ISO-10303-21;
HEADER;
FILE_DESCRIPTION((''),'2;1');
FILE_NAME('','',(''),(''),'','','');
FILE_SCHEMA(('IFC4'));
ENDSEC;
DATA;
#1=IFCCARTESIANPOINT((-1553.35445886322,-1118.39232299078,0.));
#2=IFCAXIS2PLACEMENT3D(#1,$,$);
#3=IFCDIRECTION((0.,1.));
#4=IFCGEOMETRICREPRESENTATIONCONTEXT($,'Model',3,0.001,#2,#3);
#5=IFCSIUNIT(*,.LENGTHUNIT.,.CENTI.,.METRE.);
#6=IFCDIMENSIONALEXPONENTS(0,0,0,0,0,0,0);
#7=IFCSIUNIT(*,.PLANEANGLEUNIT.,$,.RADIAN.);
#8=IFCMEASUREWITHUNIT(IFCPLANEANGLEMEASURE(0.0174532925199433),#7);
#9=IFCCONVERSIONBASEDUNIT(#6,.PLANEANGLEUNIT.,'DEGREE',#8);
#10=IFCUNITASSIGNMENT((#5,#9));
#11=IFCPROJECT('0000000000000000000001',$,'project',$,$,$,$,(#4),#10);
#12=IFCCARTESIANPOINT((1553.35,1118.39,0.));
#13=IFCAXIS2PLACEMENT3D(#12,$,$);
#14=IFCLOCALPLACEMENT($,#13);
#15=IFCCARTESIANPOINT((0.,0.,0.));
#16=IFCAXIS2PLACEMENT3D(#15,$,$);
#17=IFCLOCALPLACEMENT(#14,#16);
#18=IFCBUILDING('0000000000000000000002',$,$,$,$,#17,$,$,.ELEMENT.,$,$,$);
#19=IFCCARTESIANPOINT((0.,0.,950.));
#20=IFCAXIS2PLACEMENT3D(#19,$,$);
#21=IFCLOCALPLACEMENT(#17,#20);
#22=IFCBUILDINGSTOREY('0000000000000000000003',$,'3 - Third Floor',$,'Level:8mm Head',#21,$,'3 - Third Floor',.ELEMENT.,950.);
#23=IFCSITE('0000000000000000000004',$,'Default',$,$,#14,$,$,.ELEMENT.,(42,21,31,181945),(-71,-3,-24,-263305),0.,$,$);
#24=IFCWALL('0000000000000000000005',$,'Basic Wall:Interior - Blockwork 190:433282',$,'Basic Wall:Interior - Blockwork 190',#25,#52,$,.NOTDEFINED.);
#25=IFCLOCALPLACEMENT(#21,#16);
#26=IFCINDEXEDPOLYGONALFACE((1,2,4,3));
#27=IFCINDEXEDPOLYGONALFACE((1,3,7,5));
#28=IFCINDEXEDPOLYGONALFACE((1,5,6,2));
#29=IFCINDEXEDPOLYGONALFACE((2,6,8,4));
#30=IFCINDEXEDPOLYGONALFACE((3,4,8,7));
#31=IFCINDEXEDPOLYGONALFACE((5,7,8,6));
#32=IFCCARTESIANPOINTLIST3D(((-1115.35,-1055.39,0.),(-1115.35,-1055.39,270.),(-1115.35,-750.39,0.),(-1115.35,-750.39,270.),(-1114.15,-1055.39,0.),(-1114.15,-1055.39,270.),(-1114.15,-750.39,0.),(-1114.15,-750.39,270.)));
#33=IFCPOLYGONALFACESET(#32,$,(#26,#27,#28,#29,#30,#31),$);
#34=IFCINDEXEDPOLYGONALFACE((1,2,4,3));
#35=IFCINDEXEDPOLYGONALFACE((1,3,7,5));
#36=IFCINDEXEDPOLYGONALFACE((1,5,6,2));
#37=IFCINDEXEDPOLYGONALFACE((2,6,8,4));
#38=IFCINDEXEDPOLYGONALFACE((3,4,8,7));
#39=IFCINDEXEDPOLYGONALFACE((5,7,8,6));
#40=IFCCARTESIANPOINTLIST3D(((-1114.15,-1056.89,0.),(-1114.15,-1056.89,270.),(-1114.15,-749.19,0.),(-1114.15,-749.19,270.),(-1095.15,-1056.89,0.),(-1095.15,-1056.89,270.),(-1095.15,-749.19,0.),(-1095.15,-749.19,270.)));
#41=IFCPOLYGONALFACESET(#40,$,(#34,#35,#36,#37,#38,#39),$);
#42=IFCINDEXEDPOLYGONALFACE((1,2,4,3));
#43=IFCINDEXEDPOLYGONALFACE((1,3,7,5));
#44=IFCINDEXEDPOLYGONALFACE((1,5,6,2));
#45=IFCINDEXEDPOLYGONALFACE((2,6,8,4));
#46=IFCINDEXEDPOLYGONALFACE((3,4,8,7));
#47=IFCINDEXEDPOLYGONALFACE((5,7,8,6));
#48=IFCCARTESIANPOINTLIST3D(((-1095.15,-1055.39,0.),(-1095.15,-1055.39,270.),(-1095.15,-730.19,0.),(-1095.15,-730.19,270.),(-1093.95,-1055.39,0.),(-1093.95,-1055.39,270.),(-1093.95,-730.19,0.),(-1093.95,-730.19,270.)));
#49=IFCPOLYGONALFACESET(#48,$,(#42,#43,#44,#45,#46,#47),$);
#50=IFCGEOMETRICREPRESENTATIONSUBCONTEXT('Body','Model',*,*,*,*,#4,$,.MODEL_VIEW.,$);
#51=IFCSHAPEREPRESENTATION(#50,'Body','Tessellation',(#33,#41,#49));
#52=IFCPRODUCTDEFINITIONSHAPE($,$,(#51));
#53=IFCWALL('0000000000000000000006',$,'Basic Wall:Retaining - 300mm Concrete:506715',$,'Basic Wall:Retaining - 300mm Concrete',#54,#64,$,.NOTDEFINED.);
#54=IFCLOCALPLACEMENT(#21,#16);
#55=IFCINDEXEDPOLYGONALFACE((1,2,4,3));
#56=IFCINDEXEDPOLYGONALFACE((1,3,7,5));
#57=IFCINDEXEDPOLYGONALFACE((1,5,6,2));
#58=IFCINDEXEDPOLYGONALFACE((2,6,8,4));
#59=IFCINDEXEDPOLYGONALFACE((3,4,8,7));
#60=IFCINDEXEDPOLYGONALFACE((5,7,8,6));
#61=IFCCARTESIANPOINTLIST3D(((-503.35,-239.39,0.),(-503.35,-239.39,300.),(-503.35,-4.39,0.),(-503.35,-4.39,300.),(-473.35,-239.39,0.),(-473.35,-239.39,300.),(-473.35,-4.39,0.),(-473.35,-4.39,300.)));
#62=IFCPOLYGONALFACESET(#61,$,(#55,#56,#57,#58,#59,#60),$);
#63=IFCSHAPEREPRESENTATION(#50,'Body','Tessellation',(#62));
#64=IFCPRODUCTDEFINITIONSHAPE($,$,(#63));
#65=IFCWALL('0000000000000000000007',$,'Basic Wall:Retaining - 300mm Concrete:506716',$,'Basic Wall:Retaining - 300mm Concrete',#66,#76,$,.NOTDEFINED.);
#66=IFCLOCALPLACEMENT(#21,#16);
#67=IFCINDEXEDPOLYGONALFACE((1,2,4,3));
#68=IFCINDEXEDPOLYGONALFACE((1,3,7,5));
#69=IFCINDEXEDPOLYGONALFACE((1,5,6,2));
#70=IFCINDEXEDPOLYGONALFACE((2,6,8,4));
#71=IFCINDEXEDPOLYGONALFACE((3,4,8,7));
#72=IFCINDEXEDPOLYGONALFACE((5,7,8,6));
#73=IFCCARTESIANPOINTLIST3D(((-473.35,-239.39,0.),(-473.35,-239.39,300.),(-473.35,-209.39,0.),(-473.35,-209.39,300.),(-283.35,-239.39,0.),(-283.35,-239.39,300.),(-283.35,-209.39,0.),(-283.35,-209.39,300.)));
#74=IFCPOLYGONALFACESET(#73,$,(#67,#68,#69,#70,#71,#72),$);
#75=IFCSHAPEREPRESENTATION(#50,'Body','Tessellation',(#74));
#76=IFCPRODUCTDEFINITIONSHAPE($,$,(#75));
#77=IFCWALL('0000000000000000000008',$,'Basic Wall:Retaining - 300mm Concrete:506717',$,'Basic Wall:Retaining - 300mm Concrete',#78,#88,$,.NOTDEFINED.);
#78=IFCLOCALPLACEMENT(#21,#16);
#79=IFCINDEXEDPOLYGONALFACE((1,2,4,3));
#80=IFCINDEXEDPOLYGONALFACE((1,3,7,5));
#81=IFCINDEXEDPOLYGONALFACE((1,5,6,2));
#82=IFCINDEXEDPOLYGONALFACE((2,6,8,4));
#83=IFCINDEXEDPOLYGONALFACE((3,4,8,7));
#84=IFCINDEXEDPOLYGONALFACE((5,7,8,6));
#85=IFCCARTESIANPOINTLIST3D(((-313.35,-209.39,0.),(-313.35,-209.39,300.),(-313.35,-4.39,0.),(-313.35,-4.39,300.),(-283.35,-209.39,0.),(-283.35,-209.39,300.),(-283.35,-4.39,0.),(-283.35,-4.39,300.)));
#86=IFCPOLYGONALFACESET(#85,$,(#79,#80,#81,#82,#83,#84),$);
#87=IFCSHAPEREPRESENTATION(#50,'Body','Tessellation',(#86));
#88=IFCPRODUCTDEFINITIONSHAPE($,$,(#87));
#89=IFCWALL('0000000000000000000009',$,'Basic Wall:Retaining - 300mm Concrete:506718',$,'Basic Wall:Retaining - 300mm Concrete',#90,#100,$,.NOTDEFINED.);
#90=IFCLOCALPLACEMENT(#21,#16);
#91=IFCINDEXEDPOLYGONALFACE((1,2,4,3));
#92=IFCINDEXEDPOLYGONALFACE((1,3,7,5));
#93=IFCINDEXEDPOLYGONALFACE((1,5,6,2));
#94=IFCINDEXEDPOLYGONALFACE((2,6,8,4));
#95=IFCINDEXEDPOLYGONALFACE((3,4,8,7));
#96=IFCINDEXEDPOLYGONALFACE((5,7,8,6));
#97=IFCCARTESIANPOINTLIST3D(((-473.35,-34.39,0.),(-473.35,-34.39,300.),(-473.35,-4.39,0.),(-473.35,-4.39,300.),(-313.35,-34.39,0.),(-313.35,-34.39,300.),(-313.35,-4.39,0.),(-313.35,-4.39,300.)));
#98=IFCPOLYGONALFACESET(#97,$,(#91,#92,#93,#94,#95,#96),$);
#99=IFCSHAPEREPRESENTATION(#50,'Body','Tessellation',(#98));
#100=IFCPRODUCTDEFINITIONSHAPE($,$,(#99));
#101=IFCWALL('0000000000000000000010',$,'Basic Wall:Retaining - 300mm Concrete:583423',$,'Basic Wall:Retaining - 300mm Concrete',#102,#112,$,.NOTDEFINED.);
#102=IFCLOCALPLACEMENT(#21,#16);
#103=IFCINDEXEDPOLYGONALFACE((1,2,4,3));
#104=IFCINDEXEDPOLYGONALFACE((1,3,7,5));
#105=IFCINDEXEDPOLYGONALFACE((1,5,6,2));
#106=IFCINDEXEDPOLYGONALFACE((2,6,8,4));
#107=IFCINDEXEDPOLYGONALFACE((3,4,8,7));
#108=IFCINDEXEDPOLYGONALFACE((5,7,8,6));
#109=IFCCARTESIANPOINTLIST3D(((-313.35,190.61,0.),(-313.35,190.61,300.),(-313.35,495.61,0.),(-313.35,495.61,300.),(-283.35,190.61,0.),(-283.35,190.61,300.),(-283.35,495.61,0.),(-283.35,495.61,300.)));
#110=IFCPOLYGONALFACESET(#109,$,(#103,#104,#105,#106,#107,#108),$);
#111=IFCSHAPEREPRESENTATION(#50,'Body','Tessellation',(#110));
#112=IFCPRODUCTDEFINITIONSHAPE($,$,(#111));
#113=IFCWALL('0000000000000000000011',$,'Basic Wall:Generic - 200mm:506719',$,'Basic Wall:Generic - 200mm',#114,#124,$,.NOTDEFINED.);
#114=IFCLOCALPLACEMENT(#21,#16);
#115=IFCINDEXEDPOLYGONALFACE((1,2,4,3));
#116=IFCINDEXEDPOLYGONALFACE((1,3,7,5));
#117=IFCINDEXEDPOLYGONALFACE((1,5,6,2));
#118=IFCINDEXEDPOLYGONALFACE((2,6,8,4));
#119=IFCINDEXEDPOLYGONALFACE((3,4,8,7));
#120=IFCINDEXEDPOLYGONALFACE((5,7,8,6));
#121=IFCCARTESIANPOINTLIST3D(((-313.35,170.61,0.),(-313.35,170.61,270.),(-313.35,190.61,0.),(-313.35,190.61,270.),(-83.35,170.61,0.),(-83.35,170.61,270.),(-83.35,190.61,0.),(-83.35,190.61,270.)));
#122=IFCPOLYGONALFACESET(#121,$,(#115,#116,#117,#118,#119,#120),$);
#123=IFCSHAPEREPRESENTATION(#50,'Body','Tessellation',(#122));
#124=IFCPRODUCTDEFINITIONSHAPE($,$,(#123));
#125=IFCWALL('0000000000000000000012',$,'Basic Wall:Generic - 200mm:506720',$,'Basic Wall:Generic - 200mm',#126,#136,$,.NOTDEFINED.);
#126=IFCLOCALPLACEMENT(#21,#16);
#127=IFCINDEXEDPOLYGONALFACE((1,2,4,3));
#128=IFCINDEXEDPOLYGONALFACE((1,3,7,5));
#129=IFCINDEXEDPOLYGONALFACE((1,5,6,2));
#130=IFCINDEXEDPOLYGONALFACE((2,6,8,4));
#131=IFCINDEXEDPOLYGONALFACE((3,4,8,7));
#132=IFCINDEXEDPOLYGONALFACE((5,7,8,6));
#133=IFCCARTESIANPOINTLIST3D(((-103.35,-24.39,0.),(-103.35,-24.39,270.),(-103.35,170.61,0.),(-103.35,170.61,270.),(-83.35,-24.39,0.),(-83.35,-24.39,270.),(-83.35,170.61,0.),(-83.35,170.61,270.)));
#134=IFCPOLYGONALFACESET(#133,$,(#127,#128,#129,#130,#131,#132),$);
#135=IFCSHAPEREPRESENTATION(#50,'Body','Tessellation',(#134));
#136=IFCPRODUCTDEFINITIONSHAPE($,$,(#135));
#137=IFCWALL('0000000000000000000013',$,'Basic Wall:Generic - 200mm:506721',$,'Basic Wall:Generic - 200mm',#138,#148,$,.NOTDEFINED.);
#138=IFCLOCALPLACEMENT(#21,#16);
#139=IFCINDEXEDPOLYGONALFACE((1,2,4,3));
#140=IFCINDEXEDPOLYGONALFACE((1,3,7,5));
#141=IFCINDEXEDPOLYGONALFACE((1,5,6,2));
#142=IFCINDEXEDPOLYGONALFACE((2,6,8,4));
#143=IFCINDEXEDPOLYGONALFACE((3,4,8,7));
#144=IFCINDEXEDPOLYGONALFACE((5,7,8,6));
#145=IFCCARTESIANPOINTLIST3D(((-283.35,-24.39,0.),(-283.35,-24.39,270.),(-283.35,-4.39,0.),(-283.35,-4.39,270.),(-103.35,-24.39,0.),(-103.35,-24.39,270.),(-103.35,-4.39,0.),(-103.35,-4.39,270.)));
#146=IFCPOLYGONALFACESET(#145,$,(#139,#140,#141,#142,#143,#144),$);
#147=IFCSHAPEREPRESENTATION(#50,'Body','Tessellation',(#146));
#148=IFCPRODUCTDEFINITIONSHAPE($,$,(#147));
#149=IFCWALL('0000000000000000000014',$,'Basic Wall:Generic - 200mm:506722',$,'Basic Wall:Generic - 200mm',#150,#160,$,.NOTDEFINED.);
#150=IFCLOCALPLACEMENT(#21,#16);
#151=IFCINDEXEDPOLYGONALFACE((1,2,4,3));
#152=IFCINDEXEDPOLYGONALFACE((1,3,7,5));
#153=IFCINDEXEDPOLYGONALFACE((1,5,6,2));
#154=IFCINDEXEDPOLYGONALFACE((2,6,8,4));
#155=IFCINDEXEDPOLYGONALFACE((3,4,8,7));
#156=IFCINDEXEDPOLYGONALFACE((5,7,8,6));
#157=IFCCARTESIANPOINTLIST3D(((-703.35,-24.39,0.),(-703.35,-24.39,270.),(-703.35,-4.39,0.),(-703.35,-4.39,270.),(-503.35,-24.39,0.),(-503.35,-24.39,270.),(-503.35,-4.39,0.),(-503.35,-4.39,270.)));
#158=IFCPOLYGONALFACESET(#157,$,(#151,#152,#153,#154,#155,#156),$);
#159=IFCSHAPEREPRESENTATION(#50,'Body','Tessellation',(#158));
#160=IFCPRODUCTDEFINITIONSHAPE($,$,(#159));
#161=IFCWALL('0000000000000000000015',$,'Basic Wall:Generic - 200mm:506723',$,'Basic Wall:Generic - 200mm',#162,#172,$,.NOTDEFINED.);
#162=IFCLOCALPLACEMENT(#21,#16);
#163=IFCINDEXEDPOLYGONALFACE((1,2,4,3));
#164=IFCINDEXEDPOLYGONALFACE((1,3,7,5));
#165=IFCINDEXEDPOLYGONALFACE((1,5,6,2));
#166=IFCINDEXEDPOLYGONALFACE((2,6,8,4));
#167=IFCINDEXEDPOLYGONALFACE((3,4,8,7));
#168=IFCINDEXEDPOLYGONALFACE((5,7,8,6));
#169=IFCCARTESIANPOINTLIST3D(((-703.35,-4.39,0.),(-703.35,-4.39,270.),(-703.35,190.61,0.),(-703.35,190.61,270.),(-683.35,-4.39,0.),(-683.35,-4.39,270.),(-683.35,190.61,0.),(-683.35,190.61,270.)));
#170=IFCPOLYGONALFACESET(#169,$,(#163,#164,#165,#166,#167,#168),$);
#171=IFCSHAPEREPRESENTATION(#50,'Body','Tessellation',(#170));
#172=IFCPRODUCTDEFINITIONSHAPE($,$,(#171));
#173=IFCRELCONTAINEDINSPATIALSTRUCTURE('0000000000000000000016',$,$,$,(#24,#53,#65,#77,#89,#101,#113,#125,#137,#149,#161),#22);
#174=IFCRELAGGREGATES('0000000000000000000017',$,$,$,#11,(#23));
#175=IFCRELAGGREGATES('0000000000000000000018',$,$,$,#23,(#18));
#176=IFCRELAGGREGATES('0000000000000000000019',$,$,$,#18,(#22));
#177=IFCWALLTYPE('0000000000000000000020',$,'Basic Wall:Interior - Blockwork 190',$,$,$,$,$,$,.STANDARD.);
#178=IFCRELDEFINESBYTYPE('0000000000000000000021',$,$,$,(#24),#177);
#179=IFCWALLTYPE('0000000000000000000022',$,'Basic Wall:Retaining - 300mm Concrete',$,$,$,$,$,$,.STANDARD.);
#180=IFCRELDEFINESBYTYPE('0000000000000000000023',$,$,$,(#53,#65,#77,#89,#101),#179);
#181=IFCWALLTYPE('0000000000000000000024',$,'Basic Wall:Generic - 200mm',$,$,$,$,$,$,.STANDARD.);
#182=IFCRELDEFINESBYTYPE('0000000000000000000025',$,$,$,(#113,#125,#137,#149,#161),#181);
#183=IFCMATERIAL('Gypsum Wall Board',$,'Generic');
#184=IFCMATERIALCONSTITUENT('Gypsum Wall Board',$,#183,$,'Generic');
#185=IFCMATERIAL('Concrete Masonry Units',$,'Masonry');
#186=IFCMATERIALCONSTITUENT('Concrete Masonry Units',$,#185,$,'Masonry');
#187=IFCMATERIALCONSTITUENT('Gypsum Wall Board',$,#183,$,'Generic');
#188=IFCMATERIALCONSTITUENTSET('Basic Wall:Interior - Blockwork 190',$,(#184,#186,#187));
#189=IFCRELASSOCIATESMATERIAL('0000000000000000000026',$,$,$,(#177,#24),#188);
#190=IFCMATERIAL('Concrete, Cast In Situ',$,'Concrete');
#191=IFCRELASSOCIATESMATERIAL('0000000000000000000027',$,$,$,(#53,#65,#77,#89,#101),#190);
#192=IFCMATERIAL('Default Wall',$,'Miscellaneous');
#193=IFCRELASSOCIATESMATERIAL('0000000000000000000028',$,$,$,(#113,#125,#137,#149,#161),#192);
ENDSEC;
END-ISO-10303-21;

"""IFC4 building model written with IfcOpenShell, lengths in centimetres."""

from ifc_helpers import new_model, entity, si_unit, converted_unit, direction, frame, origin, place, context, subcontext, project, spatial, indexed_curve, outline, extrude, material, constituent, constituent_set, type_object, element, save


model = new_model("IFC4")

# Units and contexts
model_context = context("Model", 3, precision=0.001, world=frame((-1553.35445886322, -1118.39232299078, 0.0)), true_north=direction((0.0, 1.0)))
body_context = subcontext(model_context, "Body", "Model", "MODEL_VIEW")
ifc_project = project(units=[si_unit("LENGTHUNIT", "METRE", prefix="CENTI"), converted_unit("PLANEANGLEUNIT", "DEGREE", entity("IfcPlaneAngleMeasure", 0.0174532925199433), si_unit("PLANEANGLEUNIT", "RADIAN"), dimensions=[0, 0, 0, 0, 0, 0, 0])], contexts=[model_context])

# Site, building, storey
site_placement = place(None, frame((1553.35, 1118.39, 0.0)))
site = spatial("IfcSite", under=ifc_project, at=site_placement, Name="Default", CompositionType="ELEMENT", RefLatitude=(42, 21, 31, 181945), RefLongitude=(-71, -3, -24, -263305), RefElevation=0.0)
building_placement = place(site_placement, origin())
building = spatial("IfcBuilding", under=site, at=building_placement, CompositionType="ELEMENT")
storey_placement = place(building_placement, frame((0.0, 0.0, 950.0)))
storey = spatial("IfcBuildingStorey", under=building, at=storey_placement, Name="3 - Third Floor", ObjectType="Level:8mm Head", LongName="3 - Third Floor", CompositionType="ELEMENT", Elevation=950.0)

# Shared definitions
ifc_material_1 = material(Name="Concrete Masonry Units", Category="Masonry")

# Shared definitions
ifc_material_2 = material(Name="Gypsum Wall Board", Category="Generic")
ifc_constituent_1 = constituent(ifc_material_2, Name="Gypsum Wall Board", Category="Generic")
ifc_constituent_2 = constituent(ifc_material_1, Name="Concrete Masonry Units", Category="Masonry")
ifc_constituent_3 = constituent(ifc_material_2, Name="Gypsum Wall Board", Category="Generic")
ifc_constituent_set_1 = constituent_set(constituents=[ifc_constituent_1, ifc_constituent_2, ifc_constituent_3], Name="Basic Wall:Interior - Blockwork 190")
wall_type_1 = type_object("IfcWallType", Name="Basic Wall:Interior - Blockwork 190", PredefinedType="STANDARD", material=ifc_constituent_set_1)

# Walls
wall_1_placement = place(storey_placement, frame((-1104.65, -750.39, 0.0), z_axis=(0.0, 0.0, 1.0), x_axis=(0.0, -1.0, 0.0)))
element("IfcWall", 1, at=wall_1_placement, inside=storey, type_object=wall_type_1, material=ifc_constituent_set_1, Name="Basic Wall:Interior - Blockwork 190:433282", ObjectType="Basic Wall:Interior - Blockwork 190", PredefinedType="NOTDEFINED", context=body_context, shape_type="SweptSolid", body=[
    extrude(outline(indexed_curve([(-0.6, -152.5), (0.6, -152.5), (0.6, 152.5), (-0.6, 152.5), (-0.6, -152.5)], self_intersect=False)), frame((152.5, -10.1, 0.0), z_axis=(0.0, 0.0, 1.0), x_axis=(0.0, 1.0, 0.0)), (0.0, 0.0, 1.0), 270.0),
    extrude(outline(indexed_curve([(-153.85, -9.5), (153.85, -9.5), (153.85, 9.5), (-153.85, 9.5), (-153.85, -9.5)], self_intersect=False)), frame((152.65, 0.0, 0.0)), (0.0, 0.0, 1.0), 270.0),
    extrude(outline(indexed_curve([(-0.6, -162.6), (0.6, -162.6), (0.6, 162.6), (-0.6, 162.6), (-0.6, -162.6)], self_intersect=False)), frame((142.4, 10.1, 0.0), z_axis=(0.0, 0.0, 1.0), x_axis=(0.0, -1.0, 0.0)), (0.0, 0.0, 1.0), 270.0),
])
ifc_material_3 = material(Name="Concrete, Cast In Situ", Category="Concrete")
wall_type_2 = type_object("IfcWallType", Name="Basic Wall:Retaining - 300mm Concrete", PredefinedType="STANDARD")
wall_2_placement = place(storey_placement, frame((-488.35, -4.39, 0.0), z_axis=(0.0, 0.0, 1.0), x_axis=(0.0, -1.0, 0.0)))
element("IfcWall", 2, at=wall_2_placement, inside=storey, type_object=wall_type_2, material=ifc_material_3, Name="Basic Wall:Retaining - 300mm Concrete:506715", ObjectType="Basic Wall:Retaining - 300mm Concrete", PredefinedType="NOTDEFINED", context=body_context, shape_type="SweptSolid", body=[
    extrude(outline(indexed_curve([(235.0, 15.0), (0.0, 15.0), (0.0, -15.0), (235.0, -15.0), (235.0, 15.0)], self_intersect=False)), origin(), (0.0, 0.0, 1.0), 300.0),
])
wall_3_placement = place(storey_placement, frame((-473.35, -224.39, 0.0)))
element("IfcWall", 3, at=wall_3_placement, inside=storey, type_object=wall_type_2, material=ifc_material_3, Name="Basic Wall:Retaining - 300mm Concrete:506716", ObjectType="Basic Wall:Retaining - 300mm Concrete", PredefinedType="NOTDEFINED", context=body_context, shape_type="SweptSolid", body=[
    extrude(outline(indexed_curve([(190.0, 15.0), (0.0, 15.0), (0.0, -15.0), (190.0, -15.0), (190.0, 15.0)], self_intersect=False)), origin(), (0.0, 0.0, 1.0), 300.0),
])
wall_4_placement = place(storey_placement, frame((-298.35, -209.39, 0.0), z_axis=(0.0, 0.0, 1.0), x_axis=(0.0, 1.0, 0.0)))
element("IfcWall", 4, at=wall_4_placement, inside=storey, type_object=wall_type_2, material=ifc_material_3, Name="Basic Wall:Retaining - 300mm Concrete:506717", ObjectType="Basic Wall:Retaining - 300mm Concrete", PredefinedType="NOTDEFINED", context=body_context, shape_type="SweptSolid", body=[
    extrude(outline(indexed_curve([(205.0, 15.0), (0.0, 15.0), (0.0, -15.0), (205.0, -15.0), (205.0, 15.0)], self_intersect=False)), origin(), (0.0, 0.0, 1.0), 300.0),
])
wall_5_placement = place(storey_placement, frame((-313.35, -19.39, 0.0), z_axis=(0.0, 0.0, 1.0), x_axis=(-1.0, 0.0, 0.0)))
element("IfcWall", 5, at=wall_5_placement, inside=storey, type_object=wall_type_2, material=ifc_material_3, Name="Basic Wall:Retaining - 300mm Concrete:506718", ObjectType="Basic Wall:Retaining - 300mm Concrete", PredefinedType="NOTDEFINED", context=body_context, shape_type="SweptSolid", body=[
    extrude(outline(indexed_curve([(160.0, 15.0), (0.0, 15.0), (0.0, -15.0), (160.0, -15.0), (160.0, 15.0)], self_intersect=False)), origin(), (0.0, 0.0, 1.0), 300.0),
])
wall_6_placement = place(storey_placement, frame((-298.35, 495.61, 0.0), z_axis=(0.0, 0.0, 1.0), x_axis=(0.0, -1.0, 0.0)))
element("IfcWall", 6, at=wall_6_placement, inside=storey, type_object=wall_type_2, material=ifc_material_3, Name="Basic Wall:Retaining - 300mm Concrete:583423", ObjectType="Basic Wall:Retaining - 300mm Concrete", PredefinedType="NOTDEFINED", context=body_context, shape_type="SweptSolid", body=[
    extrude(outline(indexed_curve([(305.0, 15.0), (0.0, 15.0), (0.0, -15.0), (305.0, -15.0), (305.0, 15.0)], self_intersect=False)), origin(), (0.0, 0.0, 1.0), 300.0),
])
ifc_material_4 = material(Name="Default Wall", Category="Miscellaneous")
wall_type_3 = type_object("IfcWallType", Name="Basic Wall:Generic - 200mm", PredefinedType="STANDARD")
wall_7_placement = place(storey_placement, frame((-313.35, 180.61, 0.0)))
element("IfcWall", 7, at=wall_7_placement, inside=storey, type_object=wall_type_3, material=ifc_material_4, Name="Basic Wall:Generic - 200mm:506719", ObjectType="Basic Wall:Generic - 200mm", PredefinedType="NOTDEFINED", context=body_context, shape_type="SweptSolid", body=[
    extrude(outline(indexed_curve([(230.0, 10.0), (0.0, 10.0), (0.0, -10.0), (230.0, -10.0), (230.0, 10.0)], self_intersect=False)), origin(), (0.0, 0.0, 1.0), 270.0),
])
wall_8_placement = place(storey_placement, frame((-93.35, 170.61, 0.0), z_axis=(0.0, 0.0, 1.0), x_axis=(0.0, -1.0, 0.0)))
element("IfcWall", 8, at=wall_8_placement, inside=storey, type_object=wall_type_3, material=ifc_material_4, Name="Basic Wall:Generic - 200mm:506720", ObjectType="Basic Wall:Generic - 200mm", PredefinedType="NOTDEFINED", context=body_context, shape_type="SweptSolid", body=[
    extrude(outline(indexed_curve([(195.0, 10.0), (0.0, 10.0), (0.0, -10.0), (195.0, -10.0), (195.0, 10.0)], self_intersect=False)), origin(), (0.0, 0.0, 1.0), 270.0),
])
wall_9_placement = place(storey_placement, frame((-283.35, -14.39, 0.0)))
element("IfcWall", 9, at=wall_9_placement, inside=storey, type_object=wall_type_3, material=ifc_material_4, Name="Basic Wall:Generic - 200mm:506721", ObjectType="Basic Wall:Generic - 200mm", PredefinedType="NOTDEFINED", context=body_context, shape_type="SweptSolid", body=[
    extrude(outline(indexed_curve([(180.0, 10.0), (0.0, 10.0), (0.0, -10.0), (180.0, -10.0), (180.0, 10.0)], self_intersect=False)), origin(), (0.0, 0.0, 1.0), 270.0),
])
wall_10_placement = place(storey_placement, frame((-503.35, -14.39, 0.0), z_axis=(0.0, 0.0, 1.0), x_axis=(-1.0, 0.0, 0.0)))
element("IfcWall", 10, at=wall_10_placement, inside=storey, type_object=wall_type_3, material=ifc_material_4, Name="Basic Wall:Generic - 200mm:506722", ObjectType="Basic Wall:Generic - 200mm", PredefinedType="NOTDEFINED", context=body_context, shape_type="SweptSolid", body=[
    extrude(outline(indexed_curve([(200.0, 10.0), (0.0, 10.0), (0.0, -10.0), (200.0, -10.0), (200.0, 10.0)], self_intersect=False)), origin(), (0.0, 0.0, 1.0), 270.0),
])
wall_11_placement = place(storey_placement, frame((-693.35, -4.39, 0.0), z_axis=(0.0, 0.0, 1.0), x_axis=(0.0, 1.0, 0.0)))
element("IfcWall", 11, at=wall_11_placement, inside=storey, type_object=wall_type_3, material=ifc_material_4, Name="Basic Wall:Generic - 200mm:506723", ObjectType="Basic Wall:Generic - 200mm", PredefinedType="NOTDEFINED", context=body_context, shape_type="SweptSolid", body=[
    extrude(outline(indexed_curve([(195.0, 10.0), (0.0, 10.0), (0.0, -10.0), (195.0, -10.0), (195.0, 10.0)], self_intersect=False)), origin(), (0.0, 0.0, 1.0), 270.0),
])

save(model, "model.ifc")
